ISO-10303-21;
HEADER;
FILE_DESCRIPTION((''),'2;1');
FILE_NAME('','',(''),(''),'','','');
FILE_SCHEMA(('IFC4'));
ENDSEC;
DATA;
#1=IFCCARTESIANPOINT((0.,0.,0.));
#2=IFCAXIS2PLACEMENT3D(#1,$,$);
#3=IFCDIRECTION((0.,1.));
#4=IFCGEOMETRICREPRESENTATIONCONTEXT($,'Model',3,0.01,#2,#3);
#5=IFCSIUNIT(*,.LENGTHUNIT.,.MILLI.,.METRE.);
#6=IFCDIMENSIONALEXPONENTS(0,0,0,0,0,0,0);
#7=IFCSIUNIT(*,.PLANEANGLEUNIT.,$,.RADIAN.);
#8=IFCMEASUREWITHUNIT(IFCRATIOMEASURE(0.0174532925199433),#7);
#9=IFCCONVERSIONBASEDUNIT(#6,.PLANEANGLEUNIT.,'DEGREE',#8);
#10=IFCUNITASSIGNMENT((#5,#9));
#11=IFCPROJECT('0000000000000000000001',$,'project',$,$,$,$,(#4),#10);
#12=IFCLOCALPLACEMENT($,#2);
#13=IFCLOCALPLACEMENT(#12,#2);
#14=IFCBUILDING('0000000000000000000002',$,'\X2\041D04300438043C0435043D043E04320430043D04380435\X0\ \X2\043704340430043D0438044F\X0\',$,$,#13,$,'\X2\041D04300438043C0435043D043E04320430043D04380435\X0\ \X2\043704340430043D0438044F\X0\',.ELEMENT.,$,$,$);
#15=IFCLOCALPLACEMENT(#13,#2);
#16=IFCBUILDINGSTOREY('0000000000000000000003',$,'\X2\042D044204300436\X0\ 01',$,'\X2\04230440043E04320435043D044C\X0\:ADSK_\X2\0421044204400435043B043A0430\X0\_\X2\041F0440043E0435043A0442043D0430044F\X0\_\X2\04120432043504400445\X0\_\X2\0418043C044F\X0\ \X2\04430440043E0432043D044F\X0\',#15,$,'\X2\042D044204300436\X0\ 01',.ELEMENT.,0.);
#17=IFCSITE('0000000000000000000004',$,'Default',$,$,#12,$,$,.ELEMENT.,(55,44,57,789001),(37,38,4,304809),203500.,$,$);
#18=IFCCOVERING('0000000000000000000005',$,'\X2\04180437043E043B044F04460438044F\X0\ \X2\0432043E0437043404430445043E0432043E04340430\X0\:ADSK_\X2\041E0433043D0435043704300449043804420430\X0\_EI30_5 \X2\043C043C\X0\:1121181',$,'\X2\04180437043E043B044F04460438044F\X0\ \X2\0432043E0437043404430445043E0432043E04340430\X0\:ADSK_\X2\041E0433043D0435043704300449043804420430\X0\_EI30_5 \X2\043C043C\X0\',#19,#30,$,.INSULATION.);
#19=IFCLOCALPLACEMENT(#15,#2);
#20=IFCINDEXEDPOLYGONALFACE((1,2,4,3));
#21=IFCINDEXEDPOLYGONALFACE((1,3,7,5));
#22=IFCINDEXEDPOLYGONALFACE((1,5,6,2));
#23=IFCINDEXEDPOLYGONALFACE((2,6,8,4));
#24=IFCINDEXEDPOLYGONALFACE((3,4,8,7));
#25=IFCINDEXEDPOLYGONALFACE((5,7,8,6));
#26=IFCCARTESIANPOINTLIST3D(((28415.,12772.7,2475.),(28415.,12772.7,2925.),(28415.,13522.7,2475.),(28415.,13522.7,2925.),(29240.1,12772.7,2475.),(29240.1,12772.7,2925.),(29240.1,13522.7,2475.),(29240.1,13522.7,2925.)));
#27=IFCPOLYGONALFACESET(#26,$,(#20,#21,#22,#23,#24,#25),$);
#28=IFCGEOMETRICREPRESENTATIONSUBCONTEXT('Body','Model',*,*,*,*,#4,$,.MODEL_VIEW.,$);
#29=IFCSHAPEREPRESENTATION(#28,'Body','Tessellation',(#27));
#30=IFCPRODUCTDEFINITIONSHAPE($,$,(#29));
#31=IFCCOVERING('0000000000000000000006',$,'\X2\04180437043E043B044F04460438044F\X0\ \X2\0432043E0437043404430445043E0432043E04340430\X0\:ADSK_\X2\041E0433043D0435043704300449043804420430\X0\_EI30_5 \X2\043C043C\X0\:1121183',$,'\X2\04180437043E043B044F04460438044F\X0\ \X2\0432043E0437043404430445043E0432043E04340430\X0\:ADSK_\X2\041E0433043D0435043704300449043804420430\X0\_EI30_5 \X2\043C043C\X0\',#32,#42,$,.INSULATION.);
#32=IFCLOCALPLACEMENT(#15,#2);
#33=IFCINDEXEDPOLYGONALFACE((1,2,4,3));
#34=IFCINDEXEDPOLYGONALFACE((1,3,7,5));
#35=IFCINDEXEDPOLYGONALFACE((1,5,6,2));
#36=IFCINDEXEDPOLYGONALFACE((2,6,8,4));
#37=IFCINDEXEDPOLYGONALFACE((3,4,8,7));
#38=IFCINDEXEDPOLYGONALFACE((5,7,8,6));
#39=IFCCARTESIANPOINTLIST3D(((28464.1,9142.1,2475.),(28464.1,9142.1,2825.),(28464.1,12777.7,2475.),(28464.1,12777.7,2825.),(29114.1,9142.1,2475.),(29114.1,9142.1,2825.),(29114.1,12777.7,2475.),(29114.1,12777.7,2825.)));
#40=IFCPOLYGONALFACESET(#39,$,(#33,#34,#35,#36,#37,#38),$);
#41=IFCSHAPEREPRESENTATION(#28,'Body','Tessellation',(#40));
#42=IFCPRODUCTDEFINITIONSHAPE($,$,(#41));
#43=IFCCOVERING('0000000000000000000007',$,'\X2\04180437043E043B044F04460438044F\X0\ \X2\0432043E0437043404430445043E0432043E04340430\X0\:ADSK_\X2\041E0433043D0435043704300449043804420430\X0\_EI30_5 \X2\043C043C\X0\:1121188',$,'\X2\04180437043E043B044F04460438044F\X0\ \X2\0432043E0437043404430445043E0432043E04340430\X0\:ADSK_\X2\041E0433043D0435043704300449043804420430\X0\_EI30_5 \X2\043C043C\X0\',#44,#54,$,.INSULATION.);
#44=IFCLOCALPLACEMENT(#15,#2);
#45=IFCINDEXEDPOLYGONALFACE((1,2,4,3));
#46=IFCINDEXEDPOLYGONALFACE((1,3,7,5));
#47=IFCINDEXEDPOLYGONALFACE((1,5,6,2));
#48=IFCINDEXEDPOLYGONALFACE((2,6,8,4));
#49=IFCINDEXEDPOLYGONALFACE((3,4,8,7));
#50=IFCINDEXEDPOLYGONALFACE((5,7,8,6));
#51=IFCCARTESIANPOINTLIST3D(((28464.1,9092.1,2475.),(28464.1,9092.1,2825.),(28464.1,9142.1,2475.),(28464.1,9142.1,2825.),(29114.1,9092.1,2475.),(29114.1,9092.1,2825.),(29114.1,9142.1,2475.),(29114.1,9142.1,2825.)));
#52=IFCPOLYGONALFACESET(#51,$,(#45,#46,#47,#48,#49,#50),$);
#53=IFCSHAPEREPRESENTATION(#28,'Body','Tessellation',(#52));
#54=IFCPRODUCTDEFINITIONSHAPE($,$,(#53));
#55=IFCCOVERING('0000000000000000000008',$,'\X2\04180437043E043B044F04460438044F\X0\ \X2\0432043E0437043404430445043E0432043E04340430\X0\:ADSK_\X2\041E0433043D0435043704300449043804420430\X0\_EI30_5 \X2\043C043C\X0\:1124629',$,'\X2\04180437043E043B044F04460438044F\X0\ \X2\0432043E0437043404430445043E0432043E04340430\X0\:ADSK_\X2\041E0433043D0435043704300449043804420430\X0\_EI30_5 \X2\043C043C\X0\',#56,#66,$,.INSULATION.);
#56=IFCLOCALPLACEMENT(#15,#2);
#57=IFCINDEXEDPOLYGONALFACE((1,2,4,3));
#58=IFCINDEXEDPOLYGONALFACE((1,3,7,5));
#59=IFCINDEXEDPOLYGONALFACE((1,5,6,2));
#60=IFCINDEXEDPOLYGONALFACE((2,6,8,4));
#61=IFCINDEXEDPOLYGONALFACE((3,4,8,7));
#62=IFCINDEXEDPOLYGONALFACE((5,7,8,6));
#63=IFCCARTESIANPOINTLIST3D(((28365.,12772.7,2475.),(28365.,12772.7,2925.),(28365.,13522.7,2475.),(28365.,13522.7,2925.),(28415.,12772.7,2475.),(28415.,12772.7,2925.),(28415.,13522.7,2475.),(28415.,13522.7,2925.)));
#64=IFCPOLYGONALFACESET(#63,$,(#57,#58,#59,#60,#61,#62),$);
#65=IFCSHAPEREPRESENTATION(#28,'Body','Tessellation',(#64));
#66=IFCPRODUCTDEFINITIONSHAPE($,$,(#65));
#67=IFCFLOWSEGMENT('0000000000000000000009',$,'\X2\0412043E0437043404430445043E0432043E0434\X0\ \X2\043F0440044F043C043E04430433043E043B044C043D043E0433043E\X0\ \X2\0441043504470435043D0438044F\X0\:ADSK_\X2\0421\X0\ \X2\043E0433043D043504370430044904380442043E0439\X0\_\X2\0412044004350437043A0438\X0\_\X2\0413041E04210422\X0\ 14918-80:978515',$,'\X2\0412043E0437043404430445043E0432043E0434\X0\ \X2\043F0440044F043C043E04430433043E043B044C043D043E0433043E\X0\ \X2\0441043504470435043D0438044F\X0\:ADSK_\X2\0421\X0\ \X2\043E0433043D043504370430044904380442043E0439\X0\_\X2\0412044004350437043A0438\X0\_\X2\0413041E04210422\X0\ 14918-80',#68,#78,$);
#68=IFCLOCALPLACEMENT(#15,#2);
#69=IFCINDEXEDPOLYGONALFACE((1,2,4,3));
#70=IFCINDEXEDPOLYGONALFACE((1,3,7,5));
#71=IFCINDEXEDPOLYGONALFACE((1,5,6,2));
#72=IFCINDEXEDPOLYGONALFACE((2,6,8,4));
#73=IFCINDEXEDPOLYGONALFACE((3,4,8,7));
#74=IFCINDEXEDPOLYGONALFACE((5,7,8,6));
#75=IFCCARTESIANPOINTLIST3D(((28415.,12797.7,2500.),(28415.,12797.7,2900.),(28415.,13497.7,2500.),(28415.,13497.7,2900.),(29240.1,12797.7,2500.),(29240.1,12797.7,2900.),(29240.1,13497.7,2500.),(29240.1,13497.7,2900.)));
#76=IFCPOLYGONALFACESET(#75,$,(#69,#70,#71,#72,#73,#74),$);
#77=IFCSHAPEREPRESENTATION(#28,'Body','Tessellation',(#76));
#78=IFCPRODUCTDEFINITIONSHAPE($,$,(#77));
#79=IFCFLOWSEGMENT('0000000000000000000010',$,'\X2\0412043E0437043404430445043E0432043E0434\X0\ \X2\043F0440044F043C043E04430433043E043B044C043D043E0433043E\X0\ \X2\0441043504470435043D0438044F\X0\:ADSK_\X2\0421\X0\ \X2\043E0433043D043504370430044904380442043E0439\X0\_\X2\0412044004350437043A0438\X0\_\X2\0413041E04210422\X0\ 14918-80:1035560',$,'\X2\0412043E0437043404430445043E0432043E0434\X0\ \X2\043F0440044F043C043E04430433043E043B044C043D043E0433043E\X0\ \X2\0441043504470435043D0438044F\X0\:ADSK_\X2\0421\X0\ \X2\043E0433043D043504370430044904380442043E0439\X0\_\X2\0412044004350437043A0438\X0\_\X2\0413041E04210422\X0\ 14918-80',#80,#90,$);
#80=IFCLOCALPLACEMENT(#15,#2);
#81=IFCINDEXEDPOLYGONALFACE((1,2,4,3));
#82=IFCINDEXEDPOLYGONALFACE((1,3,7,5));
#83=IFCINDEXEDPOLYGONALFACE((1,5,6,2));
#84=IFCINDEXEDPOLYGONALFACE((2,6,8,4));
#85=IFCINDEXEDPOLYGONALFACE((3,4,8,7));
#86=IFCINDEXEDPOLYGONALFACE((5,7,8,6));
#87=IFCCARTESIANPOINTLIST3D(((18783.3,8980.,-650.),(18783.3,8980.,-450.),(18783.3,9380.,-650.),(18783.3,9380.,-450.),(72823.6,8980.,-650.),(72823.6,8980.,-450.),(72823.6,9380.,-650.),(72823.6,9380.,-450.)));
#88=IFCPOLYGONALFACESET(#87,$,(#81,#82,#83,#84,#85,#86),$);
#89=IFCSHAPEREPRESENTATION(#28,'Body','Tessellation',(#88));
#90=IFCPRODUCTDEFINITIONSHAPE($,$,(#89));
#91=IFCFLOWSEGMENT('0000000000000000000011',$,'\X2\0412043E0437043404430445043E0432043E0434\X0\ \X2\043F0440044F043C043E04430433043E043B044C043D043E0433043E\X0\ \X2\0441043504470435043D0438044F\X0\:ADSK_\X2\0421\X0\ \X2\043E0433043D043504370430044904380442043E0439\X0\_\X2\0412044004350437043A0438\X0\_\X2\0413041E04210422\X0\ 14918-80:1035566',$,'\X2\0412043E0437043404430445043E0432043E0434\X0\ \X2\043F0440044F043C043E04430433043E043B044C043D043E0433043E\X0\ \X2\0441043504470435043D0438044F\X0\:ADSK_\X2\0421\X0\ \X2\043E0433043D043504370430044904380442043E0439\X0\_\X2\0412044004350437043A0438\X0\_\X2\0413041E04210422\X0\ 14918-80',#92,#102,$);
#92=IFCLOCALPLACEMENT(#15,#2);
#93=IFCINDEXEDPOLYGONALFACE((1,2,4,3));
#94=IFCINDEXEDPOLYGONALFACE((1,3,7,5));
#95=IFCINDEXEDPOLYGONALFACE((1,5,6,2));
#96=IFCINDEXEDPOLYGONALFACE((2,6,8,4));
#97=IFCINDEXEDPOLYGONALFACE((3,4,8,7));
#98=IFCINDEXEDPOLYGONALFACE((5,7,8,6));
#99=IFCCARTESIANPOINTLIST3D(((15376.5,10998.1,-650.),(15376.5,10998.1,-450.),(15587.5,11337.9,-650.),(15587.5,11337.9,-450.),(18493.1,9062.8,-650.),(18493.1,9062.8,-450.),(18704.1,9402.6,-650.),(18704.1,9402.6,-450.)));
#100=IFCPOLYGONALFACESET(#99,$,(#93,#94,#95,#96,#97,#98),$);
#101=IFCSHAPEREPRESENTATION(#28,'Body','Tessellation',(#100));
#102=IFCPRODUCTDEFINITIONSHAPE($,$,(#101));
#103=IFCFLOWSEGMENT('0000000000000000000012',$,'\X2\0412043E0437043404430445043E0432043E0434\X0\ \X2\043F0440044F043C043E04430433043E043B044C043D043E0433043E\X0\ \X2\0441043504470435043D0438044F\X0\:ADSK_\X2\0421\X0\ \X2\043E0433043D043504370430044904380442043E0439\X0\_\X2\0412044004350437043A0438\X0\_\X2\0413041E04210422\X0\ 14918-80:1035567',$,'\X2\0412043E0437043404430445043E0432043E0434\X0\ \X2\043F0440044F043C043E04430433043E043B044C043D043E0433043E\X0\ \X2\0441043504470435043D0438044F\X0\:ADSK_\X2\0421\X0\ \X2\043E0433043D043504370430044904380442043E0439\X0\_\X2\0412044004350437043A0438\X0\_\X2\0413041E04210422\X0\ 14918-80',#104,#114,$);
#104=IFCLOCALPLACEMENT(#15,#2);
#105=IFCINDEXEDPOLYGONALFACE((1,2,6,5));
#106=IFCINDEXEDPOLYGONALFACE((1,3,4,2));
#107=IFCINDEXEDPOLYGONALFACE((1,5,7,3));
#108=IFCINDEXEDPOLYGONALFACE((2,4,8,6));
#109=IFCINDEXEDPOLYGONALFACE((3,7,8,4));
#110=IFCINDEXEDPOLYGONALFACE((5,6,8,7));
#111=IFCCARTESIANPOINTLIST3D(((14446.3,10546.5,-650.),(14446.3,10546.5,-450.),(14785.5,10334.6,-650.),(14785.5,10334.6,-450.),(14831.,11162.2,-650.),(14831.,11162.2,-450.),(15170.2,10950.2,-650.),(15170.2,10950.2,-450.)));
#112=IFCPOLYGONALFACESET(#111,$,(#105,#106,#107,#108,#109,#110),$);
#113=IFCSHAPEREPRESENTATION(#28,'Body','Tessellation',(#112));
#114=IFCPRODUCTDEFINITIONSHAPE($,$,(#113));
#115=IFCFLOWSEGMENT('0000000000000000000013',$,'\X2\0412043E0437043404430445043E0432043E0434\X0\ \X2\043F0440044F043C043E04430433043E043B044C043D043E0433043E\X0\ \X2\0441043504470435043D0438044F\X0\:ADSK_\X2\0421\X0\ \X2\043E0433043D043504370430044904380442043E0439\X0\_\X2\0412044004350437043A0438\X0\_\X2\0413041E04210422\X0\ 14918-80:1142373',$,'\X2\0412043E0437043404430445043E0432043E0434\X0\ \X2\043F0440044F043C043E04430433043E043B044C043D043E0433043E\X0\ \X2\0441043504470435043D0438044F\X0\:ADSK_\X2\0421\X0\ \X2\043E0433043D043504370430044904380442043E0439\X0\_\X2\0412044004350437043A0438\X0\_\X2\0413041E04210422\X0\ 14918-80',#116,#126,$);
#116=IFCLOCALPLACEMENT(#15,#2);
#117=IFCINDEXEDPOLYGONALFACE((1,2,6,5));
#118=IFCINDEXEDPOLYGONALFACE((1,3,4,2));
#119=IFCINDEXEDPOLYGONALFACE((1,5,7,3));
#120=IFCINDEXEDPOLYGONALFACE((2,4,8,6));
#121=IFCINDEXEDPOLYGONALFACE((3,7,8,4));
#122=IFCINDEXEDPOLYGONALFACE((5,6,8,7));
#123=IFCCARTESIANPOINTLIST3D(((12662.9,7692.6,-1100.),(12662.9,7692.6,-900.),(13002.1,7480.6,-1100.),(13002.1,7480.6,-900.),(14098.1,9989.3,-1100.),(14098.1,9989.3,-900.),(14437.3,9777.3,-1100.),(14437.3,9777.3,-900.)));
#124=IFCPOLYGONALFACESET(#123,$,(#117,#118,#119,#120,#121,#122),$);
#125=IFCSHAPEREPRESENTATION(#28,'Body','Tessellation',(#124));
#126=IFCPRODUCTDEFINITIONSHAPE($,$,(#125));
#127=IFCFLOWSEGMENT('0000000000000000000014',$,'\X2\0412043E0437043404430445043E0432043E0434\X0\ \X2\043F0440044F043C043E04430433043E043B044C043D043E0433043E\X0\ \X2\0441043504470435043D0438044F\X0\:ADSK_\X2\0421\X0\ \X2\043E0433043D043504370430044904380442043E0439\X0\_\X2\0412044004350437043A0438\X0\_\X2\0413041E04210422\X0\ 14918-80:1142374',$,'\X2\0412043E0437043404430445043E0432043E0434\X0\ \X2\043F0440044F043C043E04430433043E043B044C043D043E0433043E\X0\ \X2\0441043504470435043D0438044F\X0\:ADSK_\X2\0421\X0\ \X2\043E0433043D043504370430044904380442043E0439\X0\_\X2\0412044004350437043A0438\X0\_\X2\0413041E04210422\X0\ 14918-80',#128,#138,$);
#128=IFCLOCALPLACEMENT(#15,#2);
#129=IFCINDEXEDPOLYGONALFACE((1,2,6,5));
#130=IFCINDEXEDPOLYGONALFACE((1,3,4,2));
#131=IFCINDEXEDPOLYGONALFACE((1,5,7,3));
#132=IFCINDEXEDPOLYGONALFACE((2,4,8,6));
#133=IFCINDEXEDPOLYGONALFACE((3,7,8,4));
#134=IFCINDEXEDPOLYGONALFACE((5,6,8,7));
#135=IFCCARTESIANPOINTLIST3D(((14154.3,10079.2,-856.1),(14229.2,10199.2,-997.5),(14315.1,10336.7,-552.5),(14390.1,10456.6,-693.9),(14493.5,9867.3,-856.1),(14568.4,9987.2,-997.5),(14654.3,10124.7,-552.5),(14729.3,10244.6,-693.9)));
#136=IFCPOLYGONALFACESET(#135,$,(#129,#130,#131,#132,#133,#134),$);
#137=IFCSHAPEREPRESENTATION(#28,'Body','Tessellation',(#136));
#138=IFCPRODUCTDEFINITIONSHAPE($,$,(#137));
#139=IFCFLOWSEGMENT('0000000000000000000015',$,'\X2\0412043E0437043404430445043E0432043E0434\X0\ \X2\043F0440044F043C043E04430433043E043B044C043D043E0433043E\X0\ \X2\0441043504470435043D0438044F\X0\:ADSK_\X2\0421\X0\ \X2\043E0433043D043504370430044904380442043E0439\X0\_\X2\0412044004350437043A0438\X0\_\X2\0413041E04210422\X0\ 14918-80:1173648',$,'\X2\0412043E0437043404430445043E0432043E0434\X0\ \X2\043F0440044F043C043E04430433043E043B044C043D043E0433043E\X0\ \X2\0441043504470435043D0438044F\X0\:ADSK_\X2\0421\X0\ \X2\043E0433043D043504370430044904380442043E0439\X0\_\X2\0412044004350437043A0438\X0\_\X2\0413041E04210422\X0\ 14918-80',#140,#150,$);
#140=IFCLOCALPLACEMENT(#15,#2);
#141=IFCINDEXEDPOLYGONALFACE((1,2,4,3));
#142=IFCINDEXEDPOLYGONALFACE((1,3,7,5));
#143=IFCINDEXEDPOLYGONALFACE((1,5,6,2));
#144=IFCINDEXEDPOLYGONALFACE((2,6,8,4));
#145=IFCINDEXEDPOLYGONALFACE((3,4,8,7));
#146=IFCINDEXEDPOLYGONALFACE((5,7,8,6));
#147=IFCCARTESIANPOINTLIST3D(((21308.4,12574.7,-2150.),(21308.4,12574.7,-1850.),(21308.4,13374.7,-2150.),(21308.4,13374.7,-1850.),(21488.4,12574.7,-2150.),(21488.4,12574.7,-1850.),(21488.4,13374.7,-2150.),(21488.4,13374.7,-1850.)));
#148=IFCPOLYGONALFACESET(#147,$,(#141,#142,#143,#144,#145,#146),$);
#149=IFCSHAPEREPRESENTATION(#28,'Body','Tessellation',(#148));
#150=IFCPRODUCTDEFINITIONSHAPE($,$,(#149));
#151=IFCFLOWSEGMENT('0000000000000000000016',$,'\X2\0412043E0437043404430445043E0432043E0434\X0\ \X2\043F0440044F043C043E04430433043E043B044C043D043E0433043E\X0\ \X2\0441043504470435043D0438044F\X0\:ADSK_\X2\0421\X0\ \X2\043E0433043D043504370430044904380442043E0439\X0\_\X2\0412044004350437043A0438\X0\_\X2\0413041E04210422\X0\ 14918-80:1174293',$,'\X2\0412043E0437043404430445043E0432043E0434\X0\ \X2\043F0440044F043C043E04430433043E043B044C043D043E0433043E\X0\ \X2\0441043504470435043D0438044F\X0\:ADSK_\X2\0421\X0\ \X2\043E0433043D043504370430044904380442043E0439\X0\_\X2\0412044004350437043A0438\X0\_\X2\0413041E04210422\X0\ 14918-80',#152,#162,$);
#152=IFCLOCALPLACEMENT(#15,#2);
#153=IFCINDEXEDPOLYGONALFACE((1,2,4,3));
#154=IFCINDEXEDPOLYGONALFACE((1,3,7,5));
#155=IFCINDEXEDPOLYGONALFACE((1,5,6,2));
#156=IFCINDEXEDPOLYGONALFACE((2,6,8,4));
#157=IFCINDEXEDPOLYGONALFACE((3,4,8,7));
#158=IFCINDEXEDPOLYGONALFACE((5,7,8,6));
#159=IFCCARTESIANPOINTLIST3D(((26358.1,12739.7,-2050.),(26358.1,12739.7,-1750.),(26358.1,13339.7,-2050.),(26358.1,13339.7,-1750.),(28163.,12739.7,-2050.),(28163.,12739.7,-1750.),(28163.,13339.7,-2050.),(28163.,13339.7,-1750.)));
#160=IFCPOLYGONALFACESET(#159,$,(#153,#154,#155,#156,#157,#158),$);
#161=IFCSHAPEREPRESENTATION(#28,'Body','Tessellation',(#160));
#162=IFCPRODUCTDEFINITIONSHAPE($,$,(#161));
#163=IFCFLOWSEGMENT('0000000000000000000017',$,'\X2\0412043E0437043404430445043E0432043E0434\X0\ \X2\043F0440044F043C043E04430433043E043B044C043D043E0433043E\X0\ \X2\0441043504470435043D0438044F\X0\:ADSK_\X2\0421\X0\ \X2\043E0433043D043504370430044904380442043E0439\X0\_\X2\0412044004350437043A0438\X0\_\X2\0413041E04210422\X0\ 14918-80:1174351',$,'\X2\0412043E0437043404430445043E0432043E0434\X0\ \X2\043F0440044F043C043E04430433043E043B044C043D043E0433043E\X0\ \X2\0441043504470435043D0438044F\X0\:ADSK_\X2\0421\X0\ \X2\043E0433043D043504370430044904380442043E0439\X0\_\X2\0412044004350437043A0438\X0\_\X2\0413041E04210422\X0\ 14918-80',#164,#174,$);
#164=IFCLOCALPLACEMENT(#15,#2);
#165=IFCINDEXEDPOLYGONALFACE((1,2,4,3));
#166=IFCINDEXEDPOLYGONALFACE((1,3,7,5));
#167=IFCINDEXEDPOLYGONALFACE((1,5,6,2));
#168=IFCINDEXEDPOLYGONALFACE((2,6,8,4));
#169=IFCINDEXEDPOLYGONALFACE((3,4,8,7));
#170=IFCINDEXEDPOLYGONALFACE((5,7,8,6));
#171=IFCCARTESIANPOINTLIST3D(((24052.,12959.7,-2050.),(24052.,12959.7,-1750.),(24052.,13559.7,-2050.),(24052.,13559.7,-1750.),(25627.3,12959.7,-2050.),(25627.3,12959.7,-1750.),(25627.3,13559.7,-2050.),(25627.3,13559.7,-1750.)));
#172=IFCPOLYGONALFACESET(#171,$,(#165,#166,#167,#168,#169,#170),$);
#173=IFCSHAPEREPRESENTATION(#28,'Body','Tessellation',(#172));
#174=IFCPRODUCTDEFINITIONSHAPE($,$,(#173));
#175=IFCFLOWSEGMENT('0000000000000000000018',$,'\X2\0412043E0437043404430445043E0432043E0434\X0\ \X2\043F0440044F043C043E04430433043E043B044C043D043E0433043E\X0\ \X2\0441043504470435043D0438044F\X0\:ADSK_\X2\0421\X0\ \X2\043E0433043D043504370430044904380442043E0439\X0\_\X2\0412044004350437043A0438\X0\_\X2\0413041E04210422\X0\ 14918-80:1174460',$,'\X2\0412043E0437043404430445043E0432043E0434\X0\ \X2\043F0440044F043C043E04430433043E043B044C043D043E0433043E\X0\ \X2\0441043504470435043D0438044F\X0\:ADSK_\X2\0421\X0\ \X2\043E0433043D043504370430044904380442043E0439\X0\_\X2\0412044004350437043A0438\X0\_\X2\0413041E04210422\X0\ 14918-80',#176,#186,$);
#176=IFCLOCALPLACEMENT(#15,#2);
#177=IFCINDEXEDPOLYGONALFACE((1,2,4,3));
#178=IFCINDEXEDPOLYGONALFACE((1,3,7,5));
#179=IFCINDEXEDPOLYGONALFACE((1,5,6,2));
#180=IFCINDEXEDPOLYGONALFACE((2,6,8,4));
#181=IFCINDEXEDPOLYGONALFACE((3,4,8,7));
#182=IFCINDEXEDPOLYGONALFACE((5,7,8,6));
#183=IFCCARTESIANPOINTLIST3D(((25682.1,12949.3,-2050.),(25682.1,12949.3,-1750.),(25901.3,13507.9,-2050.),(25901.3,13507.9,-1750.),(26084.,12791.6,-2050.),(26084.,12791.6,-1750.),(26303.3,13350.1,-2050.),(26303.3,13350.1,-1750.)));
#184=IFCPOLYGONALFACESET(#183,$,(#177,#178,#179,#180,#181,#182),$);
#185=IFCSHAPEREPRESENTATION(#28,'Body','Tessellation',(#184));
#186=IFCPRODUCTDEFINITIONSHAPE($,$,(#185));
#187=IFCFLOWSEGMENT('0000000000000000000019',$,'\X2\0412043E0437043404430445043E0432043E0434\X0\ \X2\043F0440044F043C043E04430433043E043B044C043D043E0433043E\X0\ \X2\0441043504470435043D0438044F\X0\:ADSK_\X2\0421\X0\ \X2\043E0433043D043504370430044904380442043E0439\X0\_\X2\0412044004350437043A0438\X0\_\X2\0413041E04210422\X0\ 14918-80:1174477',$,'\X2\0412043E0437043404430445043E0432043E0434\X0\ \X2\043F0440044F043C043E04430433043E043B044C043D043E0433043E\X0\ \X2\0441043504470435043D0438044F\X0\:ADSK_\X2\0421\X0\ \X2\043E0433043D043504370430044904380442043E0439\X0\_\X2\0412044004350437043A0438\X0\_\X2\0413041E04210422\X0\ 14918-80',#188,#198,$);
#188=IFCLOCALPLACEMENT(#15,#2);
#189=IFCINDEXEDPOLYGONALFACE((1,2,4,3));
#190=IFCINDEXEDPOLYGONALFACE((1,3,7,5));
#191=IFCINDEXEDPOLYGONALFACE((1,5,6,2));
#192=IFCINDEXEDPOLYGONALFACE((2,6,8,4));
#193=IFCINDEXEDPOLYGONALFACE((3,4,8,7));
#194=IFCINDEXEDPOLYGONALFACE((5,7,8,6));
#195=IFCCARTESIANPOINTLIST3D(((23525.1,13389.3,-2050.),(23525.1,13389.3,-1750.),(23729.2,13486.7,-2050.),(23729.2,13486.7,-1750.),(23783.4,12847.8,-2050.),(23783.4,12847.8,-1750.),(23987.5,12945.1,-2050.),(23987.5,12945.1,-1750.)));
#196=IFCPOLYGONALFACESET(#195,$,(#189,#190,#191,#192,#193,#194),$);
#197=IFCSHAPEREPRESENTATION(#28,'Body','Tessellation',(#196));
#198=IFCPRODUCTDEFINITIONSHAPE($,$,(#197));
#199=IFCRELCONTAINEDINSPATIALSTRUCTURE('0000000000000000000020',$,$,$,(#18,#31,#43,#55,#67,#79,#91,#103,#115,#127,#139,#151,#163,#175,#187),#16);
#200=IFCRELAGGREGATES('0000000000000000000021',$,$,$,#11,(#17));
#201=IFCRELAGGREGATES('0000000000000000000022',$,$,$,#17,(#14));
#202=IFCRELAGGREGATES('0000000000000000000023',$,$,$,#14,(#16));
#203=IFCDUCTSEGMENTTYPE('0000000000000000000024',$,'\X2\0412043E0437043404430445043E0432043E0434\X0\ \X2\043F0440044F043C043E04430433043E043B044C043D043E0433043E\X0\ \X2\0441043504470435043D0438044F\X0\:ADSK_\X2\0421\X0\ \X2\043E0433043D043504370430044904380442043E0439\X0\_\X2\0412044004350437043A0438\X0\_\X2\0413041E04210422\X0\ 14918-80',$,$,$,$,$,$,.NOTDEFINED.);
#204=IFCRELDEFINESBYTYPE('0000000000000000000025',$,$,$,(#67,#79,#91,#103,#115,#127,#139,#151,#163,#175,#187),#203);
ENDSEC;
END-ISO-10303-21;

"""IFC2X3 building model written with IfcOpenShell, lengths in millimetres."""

from ifc_helpers import new_model, entity, si_unit, converted_unit, direction, frame, origin, origin_2d_with_axis, place, context, subcontext, project, spatial, rectangle, extrude, type_object, element, save


model = new_model("IFC2X3")

# Units and contexts
model_context = context("Model", 3, precision=0.01, world=origin(), true_north=direction((0.0, 1.0)))
body_context = subcontext(model_context, "Body", "Model", "MODEL_VIEW")
ifc_project = project(units=[si_unit("LENGTHUNIT", "METRE", prefix="MILLI"), converted_unit("PLANEANGLEUNIT", "DEGREE", entity("IfcRatioMeasure", 0.0174532925199433), si_unit("PLANEANGLEUNIT", "RADIAN"), dimensions=[0, 0, 0, 0, 0, 0, 0])], contexts=[model_context])

# Site, building, storey
site_placement = place(None, origin())
site = spatial("IfcSite", under=ifc_project, at=site_placement, Name="Default", CompositionType="ELEMENT", RefLatitude=(55, 44, 57, 789001), RefLongitude=(37, 38, 4, 304809), RefElevation=203500.0)
building_placement = place(site_placement, origin())
building = spatial("IfcBuilding", under=site, at=building_placement, Name="Наименование здания", LongName="Наименование здания", CompositionType="ELEMENT")
storey_placement = place(building_placement, origin())
storey = spatial("IfcBuildingStorey", under=building, at=storey_placement, Name="Этаж 01", ObjectType="Уровень:ADSK_Стрелка_Проектная_Вверх_Имя уровня", LongName="Этаж 01", CompositionType="ELEMENT", Elevation=0.0)

# Coverings
covering_1_placement = place(storey_placement, frame((28415.0, 12772.7, 2475.0)))
element("IfcCovering", 1, at=covering_1_placement, inside=storey, Name="Изоляция воздуховода:ADSK_Огнезащита_EI30_5 мм:1121181", ObjectType="Изоляция воздуховода:ADSK_Огнезащита_EI30_5 мм", PredefinedType="INSULATION", context=body_context, shape_type="SweptSolid", body=[
    extrude(rectangle(XDim=825.1, YDim=750.0, at=origin_2d_with_axis()), frame((412.6, 375.0, 0.0), z_axis=(0.0, 0.0, 1.0), x_axis=(-1.0, 0.0, 0.0)), (0.0, 0.0, 1.0), 450.0),
])
covering_2_placement = place(storey_placement, frame((28464.1, 9142.1, 2475.0)))
element("IfcCovering", 2, at=covering_2_placement, inside=storey, Name="Изоляция воздуховода:ADSK_Огнезащита_EI30_5 мм:1121183", ObjectType="Изоляция воздуховода:ADSK_Огнезащита_EI30_5 мм", PredefinedType="INSULATION", context=body_context, shape_type="SweptSolid", body=[
    extrude(rectangle(XDim=3635.6, YDim=650.0, at=origin_2d_with_axis()), frame((325.0, 1817.8, 0.0), z_axis=(0.0, 0.0, 1.0), x_axis=(0.0, -1.0, 0.0)), (0.0, 0.0, 1.0), 350.0),
])
covering_3_placement = place(storey_placement, frame((28464.1, 9092.1, 2475.0)))
element("IfcCovering", 3, at=covering_3_placement, inside=storey, Name="Изоляция воздуховода:ADSK_Огнезащита_EI30_5 мм:1121188", ObjectType="Изоляция воздуховода:ADSK_Огнезащита_EI30_5 мм", PredefinedType="INSULATION", context=body_context, shape_type="SweptSolid", body=[
    extrude(rectangle(XDim=50.0, YDim=650.0, at=origin_2d_with_axis()), frame((325.0, 25.0, 0.0), z_axis=(0.0, 0.0, 1.0), x_axis=(0.0, 1.0, 0.0)), (0.0, 0.0, 1.0), 350.0),
])
covering_4_placement = place(storey_placement, frame((28365.0, 12772.7, 2475.0)))
element("IfcCovering", 4, at=covering_4_placement, inside=storey, Name="Изоляция воздуховода:ADSK_Огнезащита_EI30_5 мм:1124629", ObjectType="Изоляция воздуховода:ADSK_Огнезащита_EI30_5 мм", PredefinedType="INSULATION", context=body_context, shape_type="SweptSolid", body=[
    extrude(rectangle(XDim=50.0, YDim=750.0, at=origin_2d_with_axis()), frame((25.0, 375.0, 0.0)), (0.0, 0.0, 1.0), 450.0),
])

# Flow segments
duct_segment_type = type_object("IfcDuctSegmentType", Name="Воздуховод прямоугольного сечения:ADSK_С огнезащитой_Врезки_ГОСТ 14918-80", PredefinedType="NOTDEFINED")
flow_segment_1_placement = place(storey_placement, frame((28415.0, 12797.7, 2500.0)))
element("IfcFlowSegment", 5, at=flow_segment_1_placement, inside=storey, type_object=duct_segment_type, Name="Воздуховод прямоугольного сечения:ADSK_С огнезащитой_Врезки_ГОСТ 14918-80:978515", ObjectType="Воздуховод прямоугольного сечения:ADSK_С огнезащитой_Врезки_ГОСТ 14918-80", context=body_context, shape_type="SweptSolid", body=[
    extrude(rectangle(XDim=825.1, YDim=700.0, at=origin_2d_with_axis()), frame((412.6, 350.0, 0.0), z_axis=(0.0, 0.0, 1.0), x_axis=(-1.0, 0.0, 0.0)), (0.0, 0.0, 1.0), 400.0),
])
flow_segment_2_placement = place(storey_placement, frame((18783.3, 8980.0, -650.0)))
element("IfcFlowSegment", 6, at=flow_segment_2_placement, inside=storey, type_object=duct_segment_type, Name="Воздуховод прямоугольного сечения:ADSK_С огнезащитой_Врезки_ГОСТ 14918-80:1035560", ObjectType="Воздуховод прямоугольного сечения:ADSK_С огнезащитой_Врезки_ГОСТ 14918-80", context=body_context, shape_type="SweptSolid", body=[
    extrude(rectangle(XDim=54040.3, YDim=400.0, at=origin_2d_with_axis()), frame((27020.2, 200.0, 0.0), z_axis=(0.0, 0.0, 1.0), x_axis=(-1.0, 0.0, 0.0)), (0.0, 0.0, 1.0), 200.0),
])
flow_segment_3_placement = place(storey_placement, frame((15376.5, 9062.8, -650.0)))
element("IfcFlowSegment", 7, at=flow_segment_3_placement, inside=storey, type_object=duct_segment_type, Name="Воздуховод прямоугольного сечения:ADSK_С огнезащитой_Врезки_ГОСТ 14918-80:1035566", ObjectType="Воздуховод прямоугольного сечения:ADSK_С огнезащитой_Врезки_ГОСТ 14918-80", context=body_context, shape_type="SweptSolid", body=[
    extrude(rectangle(XDim=3668.6, YDim=400.0, at=origin_2d_with_axis()), frame((1663.8, 1137.6, 0.0), z_axis=(0.0, 0.0, 1.0), x_axis=(-0.849526, 0.527546, 0.0)), (0.0, 0.0, 1.0), 200.0),
])
flow_segment_4_placement = place(storey_placement, frame((14446.3, 10334.6, -650.0)))
element("IfcFlowSegment", 8, at=flow_segment_4_placement, inside=storey, type_object=duct_segment_type, Name="Воздуховод прямоугольного сечения:ADSK_С огнезащитой_Врезки_ГОСТ 14918-80:1035567", ObjectType="Воздуховод прямоугольного сечения:ADSK_С огнезащитой_Врезки_ГОСТ 14918-80", context=body_context, shape_type="SweptSolid", body=[
    extrude(rectangle(XDim=725.9, YDim=400.0, at=origin_2d_with_axis()), frame((361.9, 413.8, 0.0), z_axis=(0.0, 0.0, 1.0), x_axis=(-0.529919, -0.848048, 0.0)), (0.0, 0.0, 1.0), 200.0),
])
flow_segment_5_placement = place(storey_placement, frame((12662.9, 7480.6, -1100.0)))
element("IfcFlowSegment", 9, at=flow_segment_5_placement, inside=storey, type_object=duct_segment_type, Name="Воздуховод прямоугольного сечения:ADSK_С огнезащитой_Врезки_ГОСТ 14918-80:1142373", ObjectType="Воздуховод прямоугольного сечения:ADSK_С огнезащитой_Врезки_ГОСТ 14918-80", context=body_context, shape_type="SweptSolid", body=[
    extrude(rectangle(XDim=2708.2, YDim=400.0, at=origin_2d_with_axis()), frame((887.2, 1254.3, 0.0), z_axis=(0.0, 0.0, 1.0), x_axis=(0.529919, 0.848048, 0.0)), (0.0, 0.0, 1.0), 200.0),
])
flow_segment_6_placement = place(storey_placement, frame((14154.3, 9867.3, -997.5)))
element("IfcFlowSegment", 10, at=flow_segment_6_placement, inside=storey, type_object=duct_segment_type, Name="Воздуховод прямоугольного сечения:ADSK_С огнезащитой_Врезки_ГОСТ 14918-80:1142374", ObjectType="Воздуховод прямоугольного сечения:ADSK_С огнезащитой_Врезки_ГОСТ 14918-80", context=body_context, shape_type="SweptSolid", body=[
    extrude(rectangle(XDim=200.0, YDim=400.0, at=origin_2d_with_axis()), frame((207.1, 165.9, 70.7), z_axis=(0.37471, 0.599661, 0.707107), x_axis=(-0.37471, -0.599661, 0.707107)), (0.0, 0.0, 1.0), 429.3),
])
flow_segment_7_placement = place(storey_placement, frame((21308.4, 12574.7, -2150.0)))
element("IfcFlowSegment", 11, at=flow_segment_7_placement, inside=storey, type_object=duct_segment_type, Name="Воздуховод прямоугольного сечения:ADSK_С огнезащитой_Врезки_ГОСТ 14918-80:1173648", ObjectType="Воздуховод прямоугольного сечения:ADSK_С огнезащитой_Врезки_ГОСТ 14918-80", context=body_context, shape_type="SweptSolid", body=[
    extrude(rectangle(XDim=180.0, YDim=800.0, at=origin_2d_with_axis()), frame((90.0, 400.0, 0.0)), (0.0, 0.0, 1.0), 300.0),
])
flow_segment_8_placement = place(storey_placement, frame((26358.1, 12739.7, -2050.0)))
element("IfcFlowSegment", 12, at=flow_segment_8_placement, inside=storey, type_object=duct_segment_type, Name="Воздуховод прямоугольного сечения:ADSK_С огнезащитой_Врезки_ГОСТ 14918-80:1174293", ObjectType="Воздуховод прямоугольного сечения:ADSK_С огнезащитой_Врезки_ГОСТ 14918-80", context=body_context, shape_type="SweptSolid", body=[
    extrude(rectangle(XDim=1804.9, YDim=600.0, at=origin_2d_with_axis()), frame((902.5, 300.0, 0.0)), (0.0, 0.0, 1.0), 300.0),
])
flow_segment_9_placement = place(storey_placement, frame((24052.0, 12959.7, -2050.0)))
element("IfcFlowSegment", 13, at=flow_segment_9_placement, inside=storey, type_object=duct_segment_type, Name="Воздуховод прямоугольного сечения:ADSK_С огнезащитой_Врезки_ГОСТ 14918-80:1174351", ObjectType="Воздуховод прямоугольного сечения:ADSK_С огнезащитой_Врезки_ГОСТ 14918-80", context=body_context, shape_type="SweptSolid", body=[
    extrude(rectangle(XDim=1575.3, YDim=600.0, at=origin_2d_with_axis()), frame((787.6, 300.0, 0.0), z_axis=(0.0, 0.0, 1.0), x_axis=(-1.0, 0.0, 0.0)), (0.0, 0.0, 1.0), 300.0),
])
flow_segment_10_placement = place(storey_placement, frame((25682.1, 12791.6, -2050.0)))
element("IfcFlowSegment", 14, at=flow_segment_10_placement, inside=storey, type_object=duct_segment_type, Name="Воздуховод прямоугольного сечения:ADSK_С огнезащитой_Врезки_ГОСТ 14918-80:1174460", ObjectType="Воздуховод прямоугольного сечения:ADSK_С огнезащитой_Врезки_ГОСТ 14918-80", context=body_context, shape_type="SweptSolid", body=[
    extrude(rectangle(XDim=431.8, YDim=600.0, at=origin_2d_with_axis()), frame((310.6, 358.1, 0.0), z_axis=(0.0, 0.0, 1.0), x_axis=(-0.930852, 0.365397, 0.0)), (0.0, 0.0, 1.0), 300.0),
])
flow_segment_11_placement = place(storey_placement, frame((23525.1, 12847.8, -2050.0)))
element("IfcFlowSegment", 15, at=flow_segment_11_placement, inside=storey, type_object=duct_segment_type, Name="Воздуховод прямоугольного сечения:ADSK_С огнезащитой_Врезки_ГОСТ 14918-80:1174477", ObjectType="Воздуховод прямоугольного сечения:ADSK_С огнезащитой_Врезки_ГОСТ 14918-80", context=body_context, shape_type="SweptSolid", body=[
    extrude(rectangle(XDim=226.1, YDim=600.0, at=origin_2d_with_axis()), frame((231.2, 319.4, 0.0), z_axis=(0.0, 0.0, 1.0), x_axis=(0.902595, 0.430491, 0.0)), (0.0, 0.0, 1.0), 300.0),
])

save(model, "model.ifc")
